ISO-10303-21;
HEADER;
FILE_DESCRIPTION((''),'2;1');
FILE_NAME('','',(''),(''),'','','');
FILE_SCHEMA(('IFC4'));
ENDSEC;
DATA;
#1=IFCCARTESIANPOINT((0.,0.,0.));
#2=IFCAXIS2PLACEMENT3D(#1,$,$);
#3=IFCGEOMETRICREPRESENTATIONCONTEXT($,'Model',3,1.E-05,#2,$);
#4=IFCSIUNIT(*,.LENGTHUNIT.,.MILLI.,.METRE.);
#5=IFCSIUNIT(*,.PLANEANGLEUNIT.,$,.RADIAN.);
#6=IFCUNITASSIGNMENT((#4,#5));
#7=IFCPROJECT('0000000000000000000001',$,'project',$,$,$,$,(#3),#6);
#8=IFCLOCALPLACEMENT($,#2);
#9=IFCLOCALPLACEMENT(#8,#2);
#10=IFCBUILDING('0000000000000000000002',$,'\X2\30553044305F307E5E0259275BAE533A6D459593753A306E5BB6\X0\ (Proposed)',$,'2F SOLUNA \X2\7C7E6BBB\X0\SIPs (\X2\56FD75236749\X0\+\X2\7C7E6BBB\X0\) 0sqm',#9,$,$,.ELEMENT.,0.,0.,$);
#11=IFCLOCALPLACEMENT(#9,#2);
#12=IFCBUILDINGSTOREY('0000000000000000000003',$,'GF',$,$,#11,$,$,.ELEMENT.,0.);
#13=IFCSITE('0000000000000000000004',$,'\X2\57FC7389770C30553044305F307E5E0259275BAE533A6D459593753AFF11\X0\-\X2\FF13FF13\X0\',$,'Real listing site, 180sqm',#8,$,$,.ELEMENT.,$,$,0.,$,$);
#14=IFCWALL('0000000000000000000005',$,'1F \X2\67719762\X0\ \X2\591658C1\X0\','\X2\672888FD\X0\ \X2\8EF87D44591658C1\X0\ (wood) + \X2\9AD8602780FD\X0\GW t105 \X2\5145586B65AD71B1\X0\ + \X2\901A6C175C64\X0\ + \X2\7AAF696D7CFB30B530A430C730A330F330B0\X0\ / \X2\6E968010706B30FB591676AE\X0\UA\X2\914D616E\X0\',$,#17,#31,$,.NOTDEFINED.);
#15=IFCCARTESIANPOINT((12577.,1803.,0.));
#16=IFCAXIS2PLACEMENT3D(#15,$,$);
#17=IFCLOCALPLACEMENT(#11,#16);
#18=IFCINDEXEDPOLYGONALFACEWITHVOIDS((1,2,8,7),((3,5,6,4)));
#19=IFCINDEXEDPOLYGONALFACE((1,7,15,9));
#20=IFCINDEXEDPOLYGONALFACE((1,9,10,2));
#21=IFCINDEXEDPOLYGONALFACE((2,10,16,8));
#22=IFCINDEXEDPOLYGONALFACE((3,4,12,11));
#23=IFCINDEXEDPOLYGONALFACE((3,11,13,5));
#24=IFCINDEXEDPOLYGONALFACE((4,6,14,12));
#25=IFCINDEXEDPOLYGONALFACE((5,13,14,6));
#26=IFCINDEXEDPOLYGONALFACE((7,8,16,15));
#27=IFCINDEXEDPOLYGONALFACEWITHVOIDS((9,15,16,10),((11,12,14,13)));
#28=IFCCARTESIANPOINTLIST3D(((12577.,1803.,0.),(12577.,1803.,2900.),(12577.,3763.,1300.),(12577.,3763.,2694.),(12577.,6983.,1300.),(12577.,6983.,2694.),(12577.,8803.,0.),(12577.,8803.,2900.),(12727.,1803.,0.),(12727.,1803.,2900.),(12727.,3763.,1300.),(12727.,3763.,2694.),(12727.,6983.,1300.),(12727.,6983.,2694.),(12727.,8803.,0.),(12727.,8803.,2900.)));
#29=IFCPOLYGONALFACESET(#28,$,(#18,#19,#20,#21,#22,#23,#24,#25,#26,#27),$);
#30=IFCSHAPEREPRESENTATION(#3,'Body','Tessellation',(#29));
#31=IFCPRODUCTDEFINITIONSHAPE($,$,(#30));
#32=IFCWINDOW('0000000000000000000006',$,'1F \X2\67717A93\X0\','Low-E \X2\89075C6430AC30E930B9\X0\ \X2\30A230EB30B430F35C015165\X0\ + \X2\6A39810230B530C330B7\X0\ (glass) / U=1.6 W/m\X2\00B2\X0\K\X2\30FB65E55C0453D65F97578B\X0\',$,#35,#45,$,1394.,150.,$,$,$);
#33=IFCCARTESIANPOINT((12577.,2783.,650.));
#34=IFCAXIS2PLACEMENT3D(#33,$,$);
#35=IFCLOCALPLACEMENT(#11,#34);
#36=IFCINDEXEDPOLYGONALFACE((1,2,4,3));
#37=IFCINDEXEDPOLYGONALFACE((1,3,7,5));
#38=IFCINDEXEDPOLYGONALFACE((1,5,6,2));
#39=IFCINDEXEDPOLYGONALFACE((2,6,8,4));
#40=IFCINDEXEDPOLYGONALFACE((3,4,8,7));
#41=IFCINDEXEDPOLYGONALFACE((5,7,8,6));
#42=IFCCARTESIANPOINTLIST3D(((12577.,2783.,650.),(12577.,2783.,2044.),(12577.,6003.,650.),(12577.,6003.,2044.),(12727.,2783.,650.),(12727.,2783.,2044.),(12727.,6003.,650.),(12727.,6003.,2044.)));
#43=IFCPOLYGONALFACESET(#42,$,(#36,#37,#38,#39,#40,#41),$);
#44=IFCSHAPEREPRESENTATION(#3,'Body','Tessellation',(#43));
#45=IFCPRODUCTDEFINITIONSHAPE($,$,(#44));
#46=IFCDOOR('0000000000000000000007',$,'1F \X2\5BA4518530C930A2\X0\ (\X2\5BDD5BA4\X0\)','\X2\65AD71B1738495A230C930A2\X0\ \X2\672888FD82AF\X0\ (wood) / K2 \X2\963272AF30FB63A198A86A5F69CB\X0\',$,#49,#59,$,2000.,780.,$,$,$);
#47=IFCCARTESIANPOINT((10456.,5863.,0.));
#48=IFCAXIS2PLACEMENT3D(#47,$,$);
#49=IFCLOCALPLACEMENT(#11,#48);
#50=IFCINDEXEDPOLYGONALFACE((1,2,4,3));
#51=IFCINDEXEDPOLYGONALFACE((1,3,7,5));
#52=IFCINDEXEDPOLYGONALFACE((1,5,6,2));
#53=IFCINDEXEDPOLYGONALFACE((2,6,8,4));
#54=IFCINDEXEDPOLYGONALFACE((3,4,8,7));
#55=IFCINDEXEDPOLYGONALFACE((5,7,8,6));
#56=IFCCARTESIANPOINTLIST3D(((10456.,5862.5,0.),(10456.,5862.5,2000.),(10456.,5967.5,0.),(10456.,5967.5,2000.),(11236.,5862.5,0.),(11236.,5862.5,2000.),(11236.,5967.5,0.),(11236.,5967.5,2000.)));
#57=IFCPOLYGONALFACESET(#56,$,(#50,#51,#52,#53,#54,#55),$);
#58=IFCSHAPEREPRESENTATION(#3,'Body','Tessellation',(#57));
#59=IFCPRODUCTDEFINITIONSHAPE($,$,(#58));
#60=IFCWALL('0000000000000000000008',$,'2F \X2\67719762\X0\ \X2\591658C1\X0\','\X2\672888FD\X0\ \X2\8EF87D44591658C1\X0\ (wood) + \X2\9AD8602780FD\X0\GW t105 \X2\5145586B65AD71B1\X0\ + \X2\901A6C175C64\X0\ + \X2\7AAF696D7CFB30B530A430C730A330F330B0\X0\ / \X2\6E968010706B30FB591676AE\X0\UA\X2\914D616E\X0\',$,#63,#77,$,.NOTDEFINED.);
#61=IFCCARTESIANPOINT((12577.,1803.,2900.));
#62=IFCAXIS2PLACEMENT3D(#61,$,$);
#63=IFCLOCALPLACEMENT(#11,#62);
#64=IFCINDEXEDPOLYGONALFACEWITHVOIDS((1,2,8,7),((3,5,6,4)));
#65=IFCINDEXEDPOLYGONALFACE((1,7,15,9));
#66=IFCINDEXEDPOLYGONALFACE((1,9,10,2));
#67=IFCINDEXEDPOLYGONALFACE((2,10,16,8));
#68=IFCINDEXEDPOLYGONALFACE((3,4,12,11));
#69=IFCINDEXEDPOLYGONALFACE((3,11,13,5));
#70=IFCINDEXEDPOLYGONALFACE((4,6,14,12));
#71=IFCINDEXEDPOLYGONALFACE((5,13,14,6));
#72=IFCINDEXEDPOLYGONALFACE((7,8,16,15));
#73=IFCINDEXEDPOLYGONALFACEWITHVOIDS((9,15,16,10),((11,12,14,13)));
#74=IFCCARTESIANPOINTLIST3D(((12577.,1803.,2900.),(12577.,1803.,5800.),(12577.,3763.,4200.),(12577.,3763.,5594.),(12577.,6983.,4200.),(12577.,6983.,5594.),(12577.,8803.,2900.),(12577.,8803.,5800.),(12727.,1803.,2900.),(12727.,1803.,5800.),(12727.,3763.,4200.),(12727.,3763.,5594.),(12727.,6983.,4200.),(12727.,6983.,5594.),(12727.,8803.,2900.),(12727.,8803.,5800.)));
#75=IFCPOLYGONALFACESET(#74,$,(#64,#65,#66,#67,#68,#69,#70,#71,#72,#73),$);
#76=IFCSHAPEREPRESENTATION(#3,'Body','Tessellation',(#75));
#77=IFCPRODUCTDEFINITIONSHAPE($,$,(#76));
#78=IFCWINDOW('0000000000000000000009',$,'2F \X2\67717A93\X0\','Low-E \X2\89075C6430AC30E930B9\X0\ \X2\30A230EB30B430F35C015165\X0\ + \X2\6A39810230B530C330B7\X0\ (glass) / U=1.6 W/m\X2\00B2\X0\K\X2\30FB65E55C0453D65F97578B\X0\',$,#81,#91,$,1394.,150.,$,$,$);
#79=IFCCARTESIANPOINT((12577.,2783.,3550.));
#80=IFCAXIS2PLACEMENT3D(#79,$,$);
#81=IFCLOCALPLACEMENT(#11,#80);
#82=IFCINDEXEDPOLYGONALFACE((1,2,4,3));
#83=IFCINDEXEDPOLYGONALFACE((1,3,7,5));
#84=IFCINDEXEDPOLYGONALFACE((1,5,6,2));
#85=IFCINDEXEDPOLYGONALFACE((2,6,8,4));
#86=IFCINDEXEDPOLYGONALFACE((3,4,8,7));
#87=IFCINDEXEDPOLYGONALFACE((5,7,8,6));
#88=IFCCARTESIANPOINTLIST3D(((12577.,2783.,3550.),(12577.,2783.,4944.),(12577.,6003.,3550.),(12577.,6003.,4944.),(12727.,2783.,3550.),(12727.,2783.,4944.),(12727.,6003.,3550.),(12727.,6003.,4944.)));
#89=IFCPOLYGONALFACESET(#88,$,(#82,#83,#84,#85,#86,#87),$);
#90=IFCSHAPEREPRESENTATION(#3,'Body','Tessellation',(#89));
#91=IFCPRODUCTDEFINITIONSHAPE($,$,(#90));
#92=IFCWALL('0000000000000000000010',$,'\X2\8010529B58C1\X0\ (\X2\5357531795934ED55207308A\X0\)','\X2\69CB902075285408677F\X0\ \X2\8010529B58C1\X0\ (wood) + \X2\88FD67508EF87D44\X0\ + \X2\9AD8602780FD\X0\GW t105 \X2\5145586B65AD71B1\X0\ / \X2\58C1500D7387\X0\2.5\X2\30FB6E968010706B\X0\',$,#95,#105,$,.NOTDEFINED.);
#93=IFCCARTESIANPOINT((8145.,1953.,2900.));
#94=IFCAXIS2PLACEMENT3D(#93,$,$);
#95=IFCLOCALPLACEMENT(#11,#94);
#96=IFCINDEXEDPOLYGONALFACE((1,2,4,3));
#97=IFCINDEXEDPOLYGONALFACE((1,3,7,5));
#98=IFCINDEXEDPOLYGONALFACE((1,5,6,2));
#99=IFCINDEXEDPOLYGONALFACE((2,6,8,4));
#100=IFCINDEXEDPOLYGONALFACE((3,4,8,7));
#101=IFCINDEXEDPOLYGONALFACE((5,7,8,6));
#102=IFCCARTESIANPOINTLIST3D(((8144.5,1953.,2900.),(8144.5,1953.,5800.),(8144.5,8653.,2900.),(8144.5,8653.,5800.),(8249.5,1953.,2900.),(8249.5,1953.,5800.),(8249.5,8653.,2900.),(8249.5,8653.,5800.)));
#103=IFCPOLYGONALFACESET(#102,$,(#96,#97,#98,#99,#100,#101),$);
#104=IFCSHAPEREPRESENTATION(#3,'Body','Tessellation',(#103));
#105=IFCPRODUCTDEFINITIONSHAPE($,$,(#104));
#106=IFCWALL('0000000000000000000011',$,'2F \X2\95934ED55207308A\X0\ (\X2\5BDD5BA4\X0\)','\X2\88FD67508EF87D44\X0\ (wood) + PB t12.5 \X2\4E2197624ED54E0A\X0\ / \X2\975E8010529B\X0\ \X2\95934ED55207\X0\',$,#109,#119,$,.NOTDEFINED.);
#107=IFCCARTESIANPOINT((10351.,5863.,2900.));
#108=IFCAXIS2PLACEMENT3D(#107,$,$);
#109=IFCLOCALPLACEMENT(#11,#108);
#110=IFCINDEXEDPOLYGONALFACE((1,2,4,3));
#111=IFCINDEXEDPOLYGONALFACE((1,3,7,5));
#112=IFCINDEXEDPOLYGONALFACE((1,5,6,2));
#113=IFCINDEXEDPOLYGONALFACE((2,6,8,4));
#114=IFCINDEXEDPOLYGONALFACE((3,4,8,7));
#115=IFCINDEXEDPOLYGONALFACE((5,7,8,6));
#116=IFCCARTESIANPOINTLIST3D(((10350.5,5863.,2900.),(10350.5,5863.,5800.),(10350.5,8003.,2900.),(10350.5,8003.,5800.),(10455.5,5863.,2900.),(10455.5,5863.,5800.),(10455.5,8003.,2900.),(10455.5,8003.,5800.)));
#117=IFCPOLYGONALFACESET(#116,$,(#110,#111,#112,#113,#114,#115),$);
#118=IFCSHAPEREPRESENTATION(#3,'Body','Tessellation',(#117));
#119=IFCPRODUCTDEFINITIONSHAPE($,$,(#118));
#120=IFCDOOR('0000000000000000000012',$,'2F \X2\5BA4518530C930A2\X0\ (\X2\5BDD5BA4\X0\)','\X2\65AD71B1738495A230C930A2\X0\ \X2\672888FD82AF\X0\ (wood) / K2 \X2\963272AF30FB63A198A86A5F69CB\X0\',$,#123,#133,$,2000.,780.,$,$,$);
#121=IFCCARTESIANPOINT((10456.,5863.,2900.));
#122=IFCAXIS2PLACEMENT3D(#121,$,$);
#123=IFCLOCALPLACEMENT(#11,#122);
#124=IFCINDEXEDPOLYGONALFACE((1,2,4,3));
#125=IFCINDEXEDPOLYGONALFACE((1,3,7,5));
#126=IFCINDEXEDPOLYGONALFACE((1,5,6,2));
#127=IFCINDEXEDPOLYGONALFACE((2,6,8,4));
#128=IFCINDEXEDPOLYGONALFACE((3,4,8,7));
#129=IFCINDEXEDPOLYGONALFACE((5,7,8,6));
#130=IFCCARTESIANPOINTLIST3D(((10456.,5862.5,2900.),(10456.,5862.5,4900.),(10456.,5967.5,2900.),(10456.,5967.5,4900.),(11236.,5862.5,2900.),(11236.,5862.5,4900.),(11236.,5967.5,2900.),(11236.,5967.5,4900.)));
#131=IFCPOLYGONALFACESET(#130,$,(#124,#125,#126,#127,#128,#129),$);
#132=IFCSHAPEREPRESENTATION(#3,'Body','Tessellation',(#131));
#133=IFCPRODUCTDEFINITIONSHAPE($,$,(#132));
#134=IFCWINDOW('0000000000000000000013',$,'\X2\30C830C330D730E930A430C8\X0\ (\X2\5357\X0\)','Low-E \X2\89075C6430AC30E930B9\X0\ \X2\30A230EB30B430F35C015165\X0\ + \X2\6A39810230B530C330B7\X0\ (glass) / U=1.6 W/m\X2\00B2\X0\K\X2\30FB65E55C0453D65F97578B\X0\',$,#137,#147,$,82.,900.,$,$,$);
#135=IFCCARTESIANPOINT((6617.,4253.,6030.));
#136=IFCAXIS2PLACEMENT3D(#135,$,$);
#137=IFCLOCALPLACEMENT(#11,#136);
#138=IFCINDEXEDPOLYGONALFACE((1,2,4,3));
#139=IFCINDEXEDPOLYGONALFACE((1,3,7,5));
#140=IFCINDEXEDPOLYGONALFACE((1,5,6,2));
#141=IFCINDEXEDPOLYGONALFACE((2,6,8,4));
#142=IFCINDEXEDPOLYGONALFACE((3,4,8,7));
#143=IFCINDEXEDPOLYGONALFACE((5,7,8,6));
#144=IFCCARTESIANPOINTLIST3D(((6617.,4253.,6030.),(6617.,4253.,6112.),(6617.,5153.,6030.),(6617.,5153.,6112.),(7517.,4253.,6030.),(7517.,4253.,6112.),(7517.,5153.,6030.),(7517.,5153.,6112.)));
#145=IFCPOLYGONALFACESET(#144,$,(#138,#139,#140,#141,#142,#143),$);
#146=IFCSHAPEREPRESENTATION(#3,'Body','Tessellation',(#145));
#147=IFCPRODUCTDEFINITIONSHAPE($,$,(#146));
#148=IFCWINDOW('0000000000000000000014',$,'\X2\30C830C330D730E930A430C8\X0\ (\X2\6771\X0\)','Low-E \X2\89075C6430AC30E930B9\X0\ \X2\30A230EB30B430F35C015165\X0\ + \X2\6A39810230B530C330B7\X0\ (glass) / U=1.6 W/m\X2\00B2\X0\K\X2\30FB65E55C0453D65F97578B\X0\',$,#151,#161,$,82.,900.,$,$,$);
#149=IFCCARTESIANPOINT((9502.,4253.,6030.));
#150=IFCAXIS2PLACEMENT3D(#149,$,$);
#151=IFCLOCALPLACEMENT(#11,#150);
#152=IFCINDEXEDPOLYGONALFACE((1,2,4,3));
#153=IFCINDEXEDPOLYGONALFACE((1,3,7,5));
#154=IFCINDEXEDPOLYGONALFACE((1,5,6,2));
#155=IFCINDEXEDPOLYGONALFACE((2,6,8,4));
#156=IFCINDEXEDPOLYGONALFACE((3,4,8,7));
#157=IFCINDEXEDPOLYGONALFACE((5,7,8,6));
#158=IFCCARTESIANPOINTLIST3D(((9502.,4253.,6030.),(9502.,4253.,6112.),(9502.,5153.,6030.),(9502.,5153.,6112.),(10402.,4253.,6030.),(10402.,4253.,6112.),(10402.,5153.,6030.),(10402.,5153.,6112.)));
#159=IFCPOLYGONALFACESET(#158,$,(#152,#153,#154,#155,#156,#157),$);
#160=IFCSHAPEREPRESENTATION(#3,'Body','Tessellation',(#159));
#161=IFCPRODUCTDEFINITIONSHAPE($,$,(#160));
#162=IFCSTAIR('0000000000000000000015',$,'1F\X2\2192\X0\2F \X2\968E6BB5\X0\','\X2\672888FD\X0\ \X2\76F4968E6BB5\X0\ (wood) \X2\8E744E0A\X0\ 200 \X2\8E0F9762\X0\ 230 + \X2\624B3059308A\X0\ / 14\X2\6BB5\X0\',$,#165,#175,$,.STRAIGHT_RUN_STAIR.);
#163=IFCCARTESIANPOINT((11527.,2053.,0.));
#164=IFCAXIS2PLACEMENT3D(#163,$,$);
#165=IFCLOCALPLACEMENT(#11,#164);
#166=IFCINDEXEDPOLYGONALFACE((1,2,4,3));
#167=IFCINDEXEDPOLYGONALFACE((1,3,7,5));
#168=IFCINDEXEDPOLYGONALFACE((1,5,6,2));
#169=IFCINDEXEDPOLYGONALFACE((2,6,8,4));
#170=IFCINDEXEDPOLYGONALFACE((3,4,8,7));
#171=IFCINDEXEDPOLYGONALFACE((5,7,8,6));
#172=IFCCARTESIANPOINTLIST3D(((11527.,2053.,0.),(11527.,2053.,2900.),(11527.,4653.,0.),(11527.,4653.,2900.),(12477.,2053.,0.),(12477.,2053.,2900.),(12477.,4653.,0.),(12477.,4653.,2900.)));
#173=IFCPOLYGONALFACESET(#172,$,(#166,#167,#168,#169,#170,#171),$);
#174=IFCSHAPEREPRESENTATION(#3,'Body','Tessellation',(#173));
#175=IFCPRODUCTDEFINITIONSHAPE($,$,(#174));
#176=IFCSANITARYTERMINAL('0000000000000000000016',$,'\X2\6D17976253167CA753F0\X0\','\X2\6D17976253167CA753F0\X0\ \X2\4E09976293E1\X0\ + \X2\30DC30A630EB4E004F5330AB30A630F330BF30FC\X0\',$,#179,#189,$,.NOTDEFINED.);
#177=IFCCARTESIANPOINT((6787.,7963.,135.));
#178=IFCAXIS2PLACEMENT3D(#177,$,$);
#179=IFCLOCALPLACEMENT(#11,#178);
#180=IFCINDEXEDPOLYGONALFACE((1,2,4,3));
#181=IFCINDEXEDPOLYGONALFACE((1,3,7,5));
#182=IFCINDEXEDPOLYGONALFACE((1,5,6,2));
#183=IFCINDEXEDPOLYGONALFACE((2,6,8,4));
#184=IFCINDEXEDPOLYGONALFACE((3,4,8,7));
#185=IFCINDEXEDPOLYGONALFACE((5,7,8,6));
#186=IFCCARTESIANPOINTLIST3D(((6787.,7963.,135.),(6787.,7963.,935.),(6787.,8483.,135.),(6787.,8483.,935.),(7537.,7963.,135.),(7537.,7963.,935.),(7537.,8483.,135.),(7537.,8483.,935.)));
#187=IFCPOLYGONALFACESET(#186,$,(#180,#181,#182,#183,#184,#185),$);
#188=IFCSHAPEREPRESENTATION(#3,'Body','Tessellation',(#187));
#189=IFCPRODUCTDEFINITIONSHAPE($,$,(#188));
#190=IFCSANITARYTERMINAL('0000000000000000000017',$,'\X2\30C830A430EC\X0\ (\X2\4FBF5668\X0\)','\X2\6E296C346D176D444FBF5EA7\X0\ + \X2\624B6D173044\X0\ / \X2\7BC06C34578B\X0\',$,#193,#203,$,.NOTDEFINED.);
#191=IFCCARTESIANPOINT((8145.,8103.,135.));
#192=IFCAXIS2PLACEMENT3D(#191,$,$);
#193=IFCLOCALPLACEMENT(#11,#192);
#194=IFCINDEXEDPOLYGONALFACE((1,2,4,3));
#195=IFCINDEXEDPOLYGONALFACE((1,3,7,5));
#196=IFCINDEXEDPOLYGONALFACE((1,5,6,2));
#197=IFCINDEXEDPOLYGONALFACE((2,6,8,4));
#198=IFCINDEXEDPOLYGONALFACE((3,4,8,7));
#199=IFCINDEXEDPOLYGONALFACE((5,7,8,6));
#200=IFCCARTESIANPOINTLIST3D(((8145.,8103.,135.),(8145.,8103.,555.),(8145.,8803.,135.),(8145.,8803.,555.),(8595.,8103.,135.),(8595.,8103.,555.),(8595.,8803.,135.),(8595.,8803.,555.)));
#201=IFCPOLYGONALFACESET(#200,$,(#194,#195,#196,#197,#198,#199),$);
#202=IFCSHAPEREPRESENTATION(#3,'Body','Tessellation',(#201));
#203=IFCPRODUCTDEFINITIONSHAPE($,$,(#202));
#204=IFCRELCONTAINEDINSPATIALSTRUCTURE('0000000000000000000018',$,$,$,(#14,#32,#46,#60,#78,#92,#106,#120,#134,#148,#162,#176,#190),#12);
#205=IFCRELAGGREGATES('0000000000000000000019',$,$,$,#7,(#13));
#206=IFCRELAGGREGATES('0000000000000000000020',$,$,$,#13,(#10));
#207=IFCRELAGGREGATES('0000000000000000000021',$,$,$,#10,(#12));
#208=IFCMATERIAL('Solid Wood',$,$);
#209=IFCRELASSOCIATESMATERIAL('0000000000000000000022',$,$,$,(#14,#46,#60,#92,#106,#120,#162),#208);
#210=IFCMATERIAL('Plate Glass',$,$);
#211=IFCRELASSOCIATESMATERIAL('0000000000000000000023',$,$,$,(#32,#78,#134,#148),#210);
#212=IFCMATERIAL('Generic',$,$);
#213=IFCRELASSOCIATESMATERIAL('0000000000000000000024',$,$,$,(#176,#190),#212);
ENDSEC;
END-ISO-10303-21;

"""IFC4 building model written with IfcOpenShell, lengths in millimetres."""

from ifc_helpers import new_model, si_unit, frame, frame_2d, origin, place, context, project, spatial, rectangle, extrude, material, element, fill, save


model = new_model("IFC4")

# Units and contexts
model_context = context("Model", 3, precision=1e-05, world=origin())
ifc_project = project(units=[si_unit("LENGTHUNIT", "METRE", prefix="MILLI"), si_unit("PLANEANGLEUNIT", "RADIAN")], contexts=[model_context])

# Site, building, storey
site_placement = place(None, origin())
site = spatial("IfcSite", under=ifc_project, at=site_placement, Name="埼玉県さいたま市大宮区浅間町１-３３", ObjectType="Real listing site, 180sqm", CompositionType="ELEMENT", RefElevation=0.0)
building_placement = place(site_placement, origin())
building = spatial("IfcBuilding", under=site, at=building_placement, Name="さいたま市大宮区浅間町の家 (Proposed)", ObjectType="2F SOLUNA 籾殻SIPs (国産杉+籾殻) 0sqm", CompositionType="ELEMENT", ElevationOfRefHeight=0.0, ElevationOfTerrain=0.0)
storey_placement = place(building_placement, origin())
storey = spatial("IfcBuildingStorey", under=building, at=storey_placement, Name="GF", CompositionType="ELEMENT", Elevation=0.0)

# Wall, opening, window
ifc_material_1 = material(Name="Solid Wood")
wall_1_placement = place(storey_placement, frame((12577.0, 1803.0, 0.0)))
wall_1 = element("IfcWall", 1, at=wall_1_placement, inside=storey, material=ifc_material_1, Name="1F 東面 外壁", Description="木製 軸組外壁 (wood) + 高性能GW t105 充填断熱 + 通気層 + 窯業系サイディング / 準耐火・外皮UA配慮", PredefinedType="NOTDEFINED", context=model_context, shape_type="SweptSolid", body=[
    extrude(rectangle(XDim=150.0, YDim=7000.0, at=frame_2d((75.0, 3500.0))), frame((12577.0, 1803.0, 0.0)), (0.0, 0.0, 1.0), 2900.0),
])
opening_1_placement = place(storey_placement, frame((12577.0, 2783.0, 650.0)))
opening_1 = element("IfcOpeningElement", 2, at=opening_1_placement, cuts=wall_1, PredefinedType="NOTDEFINED", context=model_context, shape_type="SweptSolid", body=[
    extrude(rectangle(XDim=150.0, YDim=3220.0, at=frame_2d((75.0, 1610.0))), frame((12577.0, 2783.0, 650.0)), (0.0, 0.0, 1.0), 1394.0),
])
ifc_material_2 = material(Name="Plate Glass")
window_1_placement = place(storey_placement, frame((12577.0, 2783.0, 650.0)))
window_1 = element("IfcWindow", 3, at=window_1_placement, inside=storey, material=ifc_material_2, Name="1F 東窓", Description="Low-E 複層ガラス アルゴン封入 + 樹脂サッシ (glass) / U=1.6 W/m²K・日射取得型", OverallHeight=1394.0, OverallWidth=150.0, context=model_context, shape_type="SweptSolid", body=[
    extrude(rectangle(XDim=150.0, YDim=3220.0, at=frame_2d((75.0, 1610.0))), frame((12577.0, 2783.0, 650.0)), (0.0, 0.0, 1.0), 1394.0),
])
fill(opening_1, window_1)

# Door
door_1_placement = place(storey_placement, frame((10456.0, 5863.0, 0.0)))
element("IfcDoor", 4, at=door_1_placement, inside=storey, material=ifc_material_1, Name="1F 室内ドア (寝室)", Description="断熱玄関ドア 木製芯 (wood) / K2 防犯・採風機構", OverallHeight=2000.0, OverallWidth=780.0, context=model_context, shape_type="SweptSolid", body=[
    extrude(rectangle(XDim=780.0, YDim=105.0, at=frame_2d((390.0, 52.0))), frame((10456.0, 5863.0, 0.0)), (0.0, 0.0, 1.0), 2000.0),
])

# Wall, opening, window
wall_2_placement = place(storey_placement, frame((12577.0, 1803.0, 2900.0)))
wall_2 = element("IfcWall", 5, at=wall_2_placement, inside=storey, material=ifc_material_1, Name="2F 東面 外壁", Description="木製 軸組外壁 (wood) + 高性能GW t105 充填断熱 + 通気層 + 窯業系サイディング / 準耐火・外皮UA配慮", PredefinedType="NOTDEFINED", context=model_context, shape_type="SweptSolid", body=[
    extrude(rectangle(XDim=150.0, YDim=7000.0, at=frame_2d((75.0, 3500.0))), frame((12577.0, 1803.0, 2900.0)), (0.0, 0.0, 1.0), 2900.0),
])
opening_2_placement = place(storey_placement, frame((12577.0, 2783.0, 3550.0)))
opening_2 = element("IfcOpeningElement", 6, at=opening_2_placement, cuts=wall_2, PredefinedType="NOTDEFINED", context=model_context, shape_type="SweptSolid", body=[
    extrude(rectangle(XDim=150.0, YDim=3220.0, at=frame_2d((75.0, 1610.0))), frame((12577.0, 2783.0, 3550.0)), (0.0, 0.0, 1.0), 1394.0),
])
window_2_placement = place(storey_placement, frame((12577.0, 2783.0, 3550.0)))
window_2 = element("IfcWindow", 7, at=window_2_placement, inside=storey, material=ifc_material_2, Name="2F 東窓", Description="Low-E 複層ガラス アルゴン封入 + 樹脂サッシ (glass) / U=1.6 W/m²K・日射取得型", OverallHeight=1394.0, OverallWidth=150.0, context=model_context, shape_type="SweptSolid", body=[
    extrude(rectangle(XDim=150.0, YDim=3220.0, at=frame_2d((75.0, 1610.0))), frame((12577.0, 2783.0, 3550.0)), (0.0, 0.0, 1.0), 1394.0),
])
fill(opening_2, window_2)

# Walls
wall_3_placement = place(storey_placement, frame((8145.0, 1953.0, 2900.0)))
element("IfcWall", 8, at=wall_3_placement, inside=storey, material=ifc_material_1, Name="耐力壁 (南北間仕切り)", Description="構造用合板 耐力壁 (wood) + 製材軸組 + 高性能GW t105 充填断熱 / 壁倍率2.5・準耐火", PredefinedType="NOTDEFINED", context=model_context, shape_type="SweptSolid", body=[
    extrude(rectangle(XDim=105.0, YDim=6700.0, at=frame_2d((52.0, 3350.0))), frame((8145.0, 1953.0, 2900.0)), (0.0, 0.0, 1.0), 2900.0),
])
wall_4_placement = place(storey_placement, frame((10351.0, 5863.0, 2900.0)))
element("IfcWall", 9, at=wall_4_placement, inside=storey, material=ifc_material_1, Name="2F 間仕切り (寝室)", Description="製材軸組 (wood) + PB t12.5 両面仕上 / 非耐力 間仕切", PredefinedType="NOTDEFINED", context=model_context, shape_type="SweptSolid", body=[
    extrude(rectangle(XDim=105.0, YDim=2140.0, at=frame_2d((52.0, 1070.0))), frame((10351.0, 5863.0, 2900.0)), (0.0, 0.0, 1.0), 2900.0),
])

# Door
door_2_placement = place(storey_placement, frame((10456.0, 5863.0, 2900.0)))
element("IfcDoor", 10, at=door_2_placement, inside=storey, material=ifc_material_1, Name="2F 室内ドア (寝室)", Description="断熱玄関ドア 木製芯 (wood) / K2 防犯・採風機構", OverallHeight=2000.0, OverallWidth=780.0, context=model_context, shape_type="SweptSolid", body=[
    extrude(rectangle(XDim=780.0, YDim=105.0, at=frame_2d((390.0, 52.0))), frame((10456.0, 5863.0, 2900.0)), (0.0, 0.0, 1.0), 2000.0),
])

# Windows
window_3_placement = place(storey_placement, frame((6617.0, 4253.0, 6030.0)))
element("IfcWindow", 11, at=window_3_placement, inside=storey, material=ifc_material_2, Name="トップライト (南)", Description="Low-E 複層ガラス アルゴン封入 + 樹脂サッシ (glass) / U=1.6 W/m²K・日射取得型", OverallHeight=82.0, OverallWidth=900.0, context=model_context, shape_type="SweptSolid", body=[
    extrude(rectangle(XDim=900.0, YDim=900.0, at=frame_2d((450.0, 450.0))), frame((6617.0, 4253.0, 6030.0)), (0.0, 0.0, 1.0), 82.0),
])
window_4_placement = place(storey_placement, frame((9502.0, 4253.0, 6030.0)))
element("IfcWindow", 12, at=window_4_placement, inside=storey, material=ifc_material_2, Name="トップライト (東)", Description="Low-E 複層ガラス アルゴン封入 + 樹脂サッシ (glass) / U=1.6 W/m²K・日射取得型", OverallHeight=82.0, OverallWidth=900.0, context=model_context, shape_type="SweptSolid", body=[
    extrude(rectangle(XDim=900.0, YDim=900.0, at=frame_2d((450.0, 450.0))), frame((9502.0, 4253.0, 6030.0)), (0.0, 0.0, 1.0), 82.0),
])

# Stair
stair_placement = place(storey_placement, frame((11527.0, 2053.0, 0.0)))
element("IfcStair", 13, at=stair_placement, inside=storey, material=ifc_material_1, Name="1F→2F 階段", Description="木製 直階段 (wood) 蹴上 200 踏面 230 + 手すり / 14段", PredefinedType="STRAIGHT_RUN_STAIR", context=model_context, shape_type="SweptSolid", body=[
    extrude(rectangle(XDim=950.0, YDim=2600.0, at=frame_2d((475.0, 1300.0))), frame((11527.0, 2053.0, 0.0)), (0.0, 0.0, 1.0), 2900.0),
])

# Sanitary terminals
ifc_material_3 = material(Name="Generic")
sanitary_terminal_1_placement = place(storey_placement, frame((6787.0, 7963.0, 135.0)))
element("IfcSanitaryTerminal", 14, at=sanitary_terminal_1_placement, inside=storey, material=ifc_material_3, Name="洗面化粧台", Description="洗面化粧台 三面鏡 + ボウル一体カウンター", PredefinedType="NOTDEFINED", context=model_context, shape_type="SweptSolid", body=[
    extrude(rectangle(XDim=750.0, YDim=520.0, at=frame_2d((375.0, 260.0))), frame((6787.0, 7963.0, 135.0)), (0.0, 0.0, 1.0), 800.0),
])
sanitary_terminal_2_placement = place(storey_placement, frame((8145.0, 8103.0, 135.0)))
element("IfcSanitaryTerminal", 15, at=sanitary_terminal_2_placement, inside=storey, material=ifc_material_3, Name="トイレ (便器)", Description="温水洗浄便座 + 手洗い / 節水型", PredefinedType="NOTDEFINED", context=model_context, shape_type="SweptSolid", body=[
    extrude(rectangle(XDim=450.0, YDim=700.0, at=frame_2d((225.0, 350.0))), frame((8145.0, 8103.0, 135.0)), (0.0, 0.0, 1.0), 420.0),
])

save(model, "model.ifc")
